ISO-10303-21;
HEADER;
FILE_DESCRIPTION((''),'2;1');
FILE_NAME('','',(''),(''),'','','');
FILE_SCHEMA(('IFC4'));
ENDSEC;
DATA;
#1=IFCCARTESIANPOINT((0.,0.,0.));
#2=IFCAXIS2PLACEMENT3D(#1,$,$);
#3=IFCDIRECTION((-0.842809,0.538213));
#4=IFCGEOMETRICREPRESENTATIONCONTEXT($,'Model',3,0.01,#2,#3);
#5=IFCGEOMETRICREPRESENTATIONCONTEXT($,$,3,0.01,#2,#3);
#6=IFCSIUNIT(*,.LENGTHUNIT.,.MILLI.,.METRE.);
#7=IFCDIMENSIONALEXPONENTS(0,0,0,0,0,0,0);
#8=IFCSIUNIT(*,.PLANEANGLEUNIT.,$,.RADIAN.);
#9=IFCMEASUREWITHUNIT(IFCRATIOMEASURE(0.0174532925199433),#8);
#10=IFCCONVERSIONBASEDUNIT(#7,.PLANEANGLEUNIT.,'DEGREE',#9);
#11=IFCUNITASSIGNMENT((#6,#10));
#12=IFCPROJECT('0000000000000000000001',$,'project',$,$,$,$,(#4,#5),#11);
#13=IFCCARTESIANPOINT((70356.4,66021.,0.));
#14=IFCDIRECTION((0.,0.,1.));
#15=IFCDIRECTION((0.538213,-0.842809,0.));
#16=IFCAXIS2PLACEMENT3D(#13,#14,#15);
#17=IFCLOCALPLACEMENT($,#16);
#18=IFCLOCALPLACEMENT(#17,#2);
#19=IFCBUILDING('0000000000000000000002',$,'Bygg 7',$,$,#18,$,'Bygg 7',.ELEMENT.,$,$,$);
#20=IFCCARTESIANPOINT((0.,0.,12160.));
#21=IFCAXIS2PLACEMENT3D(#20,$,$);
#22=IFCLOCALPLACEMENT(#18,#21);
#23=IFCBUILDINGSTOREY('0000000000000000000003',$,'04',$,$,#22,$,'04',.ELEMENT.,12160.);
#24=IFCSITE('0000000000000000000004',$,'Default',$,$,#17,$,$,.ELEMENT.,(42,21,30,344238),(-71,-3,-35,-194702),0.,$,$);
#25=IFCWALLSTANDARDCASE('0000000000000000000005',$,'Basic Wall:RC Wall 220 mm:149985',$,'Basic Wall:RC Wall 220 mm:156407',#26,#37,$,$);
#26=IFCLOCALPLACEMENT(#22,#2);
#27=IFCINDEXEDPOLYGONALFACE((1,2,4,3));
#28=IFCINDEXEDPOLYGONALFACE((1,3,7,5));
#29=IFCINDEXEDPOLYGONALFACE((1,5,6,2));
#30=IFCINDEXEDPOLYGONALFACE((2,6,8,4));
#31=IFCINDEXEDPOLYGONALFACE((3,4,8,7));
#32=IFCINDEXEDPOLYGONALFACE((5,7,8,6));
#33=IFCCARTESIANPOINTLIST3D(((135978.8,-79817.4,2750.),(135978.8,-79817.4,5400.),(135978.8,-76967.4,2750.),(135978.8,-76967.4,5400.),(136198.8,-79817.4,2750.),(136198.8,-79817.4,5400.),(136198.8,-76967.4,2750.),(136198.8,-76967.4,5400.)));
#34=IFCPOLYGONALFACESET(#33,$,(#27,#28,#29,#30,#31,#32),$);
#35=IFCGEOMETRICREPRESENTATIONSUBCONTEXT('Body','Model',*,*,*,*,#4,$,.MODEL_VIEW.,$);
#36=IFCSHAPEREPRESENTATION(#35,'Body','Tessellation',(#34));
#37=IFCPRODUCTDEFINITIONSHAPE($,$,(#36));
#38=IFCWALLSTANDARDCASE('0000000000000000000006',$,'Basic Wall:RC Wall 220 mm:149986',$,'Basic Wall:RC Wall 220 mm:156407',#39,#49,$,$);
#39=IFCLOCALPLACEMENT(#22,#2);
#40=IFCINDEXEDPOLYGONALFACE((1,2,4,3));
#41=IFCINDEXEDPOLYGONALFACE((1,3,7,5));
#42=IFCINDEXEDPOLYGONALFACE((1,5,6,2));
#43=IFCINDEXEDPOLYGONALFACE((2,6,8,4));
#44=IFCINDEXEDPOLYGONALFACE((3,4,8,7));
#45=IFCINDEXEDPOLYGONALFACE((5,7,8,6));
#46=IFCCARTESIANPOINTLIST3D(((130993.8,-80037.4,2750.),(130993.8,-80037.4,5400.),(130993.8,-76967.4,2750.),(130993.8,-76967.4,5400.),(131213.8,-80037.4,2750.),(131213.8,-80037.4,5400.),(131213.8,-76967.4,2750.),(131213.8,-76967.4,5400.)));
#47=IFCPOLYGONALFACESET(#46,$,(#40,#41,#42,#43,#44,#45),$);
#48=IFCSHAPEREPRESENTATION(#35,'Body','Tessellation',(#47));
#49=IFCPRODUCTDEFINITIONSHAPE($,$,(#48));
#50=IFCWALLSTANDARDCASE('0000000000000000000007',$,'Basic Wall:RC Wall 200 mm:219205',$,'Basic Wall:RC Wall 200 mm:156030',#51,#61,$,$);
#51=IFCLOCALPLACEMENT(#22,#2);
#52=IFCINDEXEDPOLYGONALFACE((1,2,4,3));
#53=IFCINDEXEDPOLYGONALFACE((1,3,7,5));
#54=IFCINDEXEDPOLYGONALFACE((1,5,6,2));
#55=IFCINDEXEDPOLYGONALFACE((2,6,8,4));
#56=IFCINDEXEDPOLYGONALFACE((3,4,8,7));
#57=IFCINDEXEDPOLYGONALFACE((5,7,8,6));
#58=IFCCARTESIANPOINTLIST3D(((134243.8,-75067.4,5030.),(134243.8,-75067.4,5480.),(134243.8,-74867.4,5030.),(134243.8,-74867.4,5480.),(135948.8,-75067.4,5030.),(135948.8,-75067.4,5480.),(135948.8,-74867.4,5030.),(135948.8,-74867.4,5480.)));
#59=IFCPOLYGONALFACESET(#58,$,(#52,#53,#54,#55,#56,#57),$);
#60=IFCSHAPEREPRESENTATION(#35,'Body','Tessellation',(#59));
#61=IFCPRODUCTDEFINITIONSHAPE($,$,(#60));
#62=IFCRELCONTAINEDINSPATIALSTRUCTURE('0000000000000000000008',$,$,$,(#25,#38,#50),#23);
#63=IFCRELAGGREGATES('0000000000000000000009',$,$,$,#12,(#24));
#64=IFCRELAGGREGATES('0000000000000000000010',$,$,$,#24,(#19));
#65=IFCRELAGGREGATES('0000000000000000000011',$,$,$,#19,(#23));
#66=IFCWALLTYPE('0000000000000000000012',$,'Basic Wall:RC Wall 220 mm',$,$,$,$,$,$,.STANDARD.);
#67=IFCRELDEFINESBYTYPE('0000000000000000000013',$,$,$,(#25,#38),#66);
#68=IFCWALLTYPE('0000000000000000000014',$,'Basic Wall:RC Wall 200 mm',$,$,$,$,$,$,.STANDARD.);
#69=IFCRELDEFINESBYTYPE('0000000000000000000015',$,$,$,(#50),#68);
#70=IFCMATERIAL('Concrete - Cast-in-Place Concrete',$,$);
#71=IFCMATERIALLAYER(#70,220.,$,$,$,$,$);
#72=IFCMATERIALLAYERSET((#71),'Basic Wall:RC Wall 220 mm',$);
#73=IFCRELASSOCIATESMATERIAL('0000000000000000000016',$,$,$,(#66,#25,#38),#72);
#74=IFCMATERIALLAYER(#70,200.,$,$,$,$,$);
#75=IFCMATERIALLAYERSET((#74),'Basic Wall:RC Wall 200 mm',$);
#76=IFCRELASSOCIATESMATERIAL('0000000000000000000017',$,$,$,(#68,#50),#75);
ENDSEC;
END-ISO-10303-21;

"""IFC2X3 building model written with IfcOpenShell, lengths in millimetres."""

from ifc_helpers import new_model, entity, si_unit, converted_unit, direction, frame, frame_2d, origin, place, context, subcontext, project, spatial, polyline, rectangle, extrude, clip, bounded_halfspace, material, layer, layer_set, layer_usage, type_object, element, save


model = new_model("IFC2X3")

# Units and contexts
model_context = context("Model", 3, precision=0.01, world=origin(), true_north=direction((-0.842809, 0.538213)))
context_of_model = context(None, 3, precision=0.01, world=origin(), true_north=direction((-0.842809, 0.538213)))
body_context = subcontext(model_context, "Body", "Model", "MODEL_VIEW")
ifc_project = project(units=[si_unit("LENGTHUNIT", "METRE", prefix="MILLI"), converted_unit("PLANEANGLEUNIT", "DEGREE", entity("IfcRatioMeasure", 0.0174532925199433), si_unit("PLANEANGLEUNIT", "RADIAN"), dimensions=[0, 0, 0, 0, 0, 0, 0])], contexts=[model_context, context_of_model])

# Site, building, storey
site_placement = place(None, frame((70356.4, 66021.0, 0.0), z_axis=(0.0, 0.0, 1.0), x_axis=(0.538213, -0.842809, 0.0)))
site = spatial("IfcSite", under=ifc_project, at=site_placement, Name="Default", CompositionType="ELEMENT", RefLatitude=(42, 21, 30, 344238), RefLongitude=(-71, -3, -35, -194702), RefElevation=0.0)
building_placement = place(site_placement, origin())
building = spatial("IfcBuilding", under=site, at=building_placement, Name="Bygg 7", LongName="Bygg 7", CompositionType="ELEMENT")
storey_placement = place(building_placement, frame((0.0, 0.0, 12160.0)))
storey = spatial("IfcBuildingStorey", under=building, at=storey_placement, Name="04", LongName="04", CompositionType="ELEMENT", Elevation=12160.0)

# Shared definitions
ifc_material_1 = material(Name="Concrete - Cast-in-Place Concrete")

# Shared definitions
ifc_layer_1 = layer(ifc_material_1, 220.0)
ifc_layer_set_1 = layer_set([ifc_layer_1], Name="Basic Wall:RC Wall 220 mm")
wall_type_1 = type_object("IfcWallType", Name="Basic Wall:RC Wall 220 mm", PredefinedType="STANDARD", material=ifc_layer_set_1)

# Walls
ifc_layer_usage_1 = layer_usage(ifc_layer_set_1, "AXIS2", "NEGATIVE", 110.0)
wall_1_placement = place(storey_placement, frame((136088.8, -79817.4, 2750.0), z_axis=(0.0, 0.0, 1.0), x_axis=(0.0, 1.0, 0.0)))
element("IfcWallStandardCase", 1, at=wall_1_placement, inside=storey, type_object=wall_type_1, material=ifc_layer_usage_1, Name="Basic Wall:RC Wall 220 mm:149985", ObjectType="Basic Wall:RC Wall 220 mm:156407", context=body_context, shape_type="Clipping", body=[
    clip(clip(extrude(rectangle(XDim=2850.0, YDim=220.0, at=frame_2d((1425.0, 0.0), x_axis=(-1.0, 0.0))), origin(), (0.0, 0.0, 1.0), 2650.0), bounded_halfspace(frame((0.0, -110.0, 2650.0), z_axis=(0.0, 0.0, -1.0), x_axis=(-0.99571, -0.092529, 0.0)), True, frame((0.0, -110.0, 2650.0)), polyline([(0.0, 0.0), (2850.0, 0.0), (2850.0, 220.0), (454.0, 220.0), (0.0, 220.0), (0.0, 0.0)]))), bounded_halfspace(frame((2850.0, -110.0, 0.0), z_axis=(0.0, 0.0, 1.0), x_axis=(0.99571, 0.092529, 0.0)), True, frame((2850.0, -110.0, 0.0)), polyline([(0.0, 0.0), (0.0, 220.0), (-2396.0, 220.0), (-2850.0, 220.0), (-2850.0, 0.0), (0.0, 0.0)]))),
])
ifc_layer_usage_2 = layer_usage(ifc_layer_set_1, "AXIS2", "NEGATIVE", 110.0)
wall_2_placement = place(storey_placement, frame((131103.8, -80037.4, 2750.0), z_axis=(0.0, 0.0, 1.0), x_axis=(0.0, 1.0, 0.0)))
element("IfcWallStandardCase", 2, at=wall_2_placement, inside=storey, type_object=wall_type_1, material=ifc_layer_usage_2, Name="Basic Wall:RC Wall 220 mm:149986", ObjectType="Basic Wall:RC Wall 220 mm:156407", context=body_context, shape_type="Clipping", body=[
    clip(clip(extrude(rectangle(XDim=3070.0, YDim=220.0, at=frame_2d((1535.0, 0.0), x_axis=(-1.0, 0.0))), origin(), (0.0, 0.0, 1.0), 2650.0), bounded_halfspace(frame((0.0, -110.0, 2650.0), z_axis=(0.0, 0.0, -1.0), x_axis=(-0.99571, -0.092529, 0.0)), True, frame((0.0, -110.0, 2650.0)), polyline([(0.0, 0.0), (3070.0, 0.0), (3070.0, 220.0), (220.0, 220.0), (0.0, 220.0), (0.0, 0.0)]))), bounded_halfspace(frame((3070.0, -110.0, 0.0), z_axis=(0.0, 0.0, 1.0), x_axis=(0.99571, 0.092529, 0.0)), True, frame((3070.0, -110.0, 0.0)), polyline([(0.0, 0.0), (0.0, 220.0), (-2850.0, 220.0), (-3070.0, 220.0), (-3070.0, 0.0), (0.0, 0.0)]))),
])
ifc_layer_2 = layer(ifc_material_1, 200.0)
ifc_layer_set_2 = layer_set([ifc_layer_2], Name="Basic Wall:RC Wall 200 mm")
ifc_layer_usage_3 = layer_usage(ifc_layer_set_2, "AXIS2", "NEGATIVE", 100.0)
wall_type_2 = type_object("IfcWallType", Name="Basic Wall:RC Wall 200 mm", PredefinedType="STANDARD", material=ifc_layer_set_2)
wall_3_placement = place(storey_placement, frame((134243.8, -74967.4, 5030.0)))
element("IfcWallStandardCase", 3, at=wall_3_placement, inside=storey, type_object=wall_type_2, material=ifc_layer_usage_3, Name="Basic Wall:RC Wall 200 mm:219205", ObjectType="Basic Wall:RC Wall 200 mm:156030", context=body_context, shape_type="Clipping", body=[
    clip(extrude(rectangle(XDim=1705.0, YDim=200.0, at=frame_2d((852.5, 0.0), x_axis=(-1.0, 0.0))), origin(), (0.0, 0.0, 1.0), 450.0), bounded_halfspace(frame((0.0, -100.0, 450.0), z_axis=(0.0, 0.0, -1.0), x_axis=(1.0, 0.0, 0.0)), True, frame((0.0, -100.0, 450.0)), polyline([(0.0, 0.0), (1705.0, 0.0), (1705.0, 200.0), (0.0, 200.0), (0.0, 0.0)]))),
])

save(model, "model.ifc")
